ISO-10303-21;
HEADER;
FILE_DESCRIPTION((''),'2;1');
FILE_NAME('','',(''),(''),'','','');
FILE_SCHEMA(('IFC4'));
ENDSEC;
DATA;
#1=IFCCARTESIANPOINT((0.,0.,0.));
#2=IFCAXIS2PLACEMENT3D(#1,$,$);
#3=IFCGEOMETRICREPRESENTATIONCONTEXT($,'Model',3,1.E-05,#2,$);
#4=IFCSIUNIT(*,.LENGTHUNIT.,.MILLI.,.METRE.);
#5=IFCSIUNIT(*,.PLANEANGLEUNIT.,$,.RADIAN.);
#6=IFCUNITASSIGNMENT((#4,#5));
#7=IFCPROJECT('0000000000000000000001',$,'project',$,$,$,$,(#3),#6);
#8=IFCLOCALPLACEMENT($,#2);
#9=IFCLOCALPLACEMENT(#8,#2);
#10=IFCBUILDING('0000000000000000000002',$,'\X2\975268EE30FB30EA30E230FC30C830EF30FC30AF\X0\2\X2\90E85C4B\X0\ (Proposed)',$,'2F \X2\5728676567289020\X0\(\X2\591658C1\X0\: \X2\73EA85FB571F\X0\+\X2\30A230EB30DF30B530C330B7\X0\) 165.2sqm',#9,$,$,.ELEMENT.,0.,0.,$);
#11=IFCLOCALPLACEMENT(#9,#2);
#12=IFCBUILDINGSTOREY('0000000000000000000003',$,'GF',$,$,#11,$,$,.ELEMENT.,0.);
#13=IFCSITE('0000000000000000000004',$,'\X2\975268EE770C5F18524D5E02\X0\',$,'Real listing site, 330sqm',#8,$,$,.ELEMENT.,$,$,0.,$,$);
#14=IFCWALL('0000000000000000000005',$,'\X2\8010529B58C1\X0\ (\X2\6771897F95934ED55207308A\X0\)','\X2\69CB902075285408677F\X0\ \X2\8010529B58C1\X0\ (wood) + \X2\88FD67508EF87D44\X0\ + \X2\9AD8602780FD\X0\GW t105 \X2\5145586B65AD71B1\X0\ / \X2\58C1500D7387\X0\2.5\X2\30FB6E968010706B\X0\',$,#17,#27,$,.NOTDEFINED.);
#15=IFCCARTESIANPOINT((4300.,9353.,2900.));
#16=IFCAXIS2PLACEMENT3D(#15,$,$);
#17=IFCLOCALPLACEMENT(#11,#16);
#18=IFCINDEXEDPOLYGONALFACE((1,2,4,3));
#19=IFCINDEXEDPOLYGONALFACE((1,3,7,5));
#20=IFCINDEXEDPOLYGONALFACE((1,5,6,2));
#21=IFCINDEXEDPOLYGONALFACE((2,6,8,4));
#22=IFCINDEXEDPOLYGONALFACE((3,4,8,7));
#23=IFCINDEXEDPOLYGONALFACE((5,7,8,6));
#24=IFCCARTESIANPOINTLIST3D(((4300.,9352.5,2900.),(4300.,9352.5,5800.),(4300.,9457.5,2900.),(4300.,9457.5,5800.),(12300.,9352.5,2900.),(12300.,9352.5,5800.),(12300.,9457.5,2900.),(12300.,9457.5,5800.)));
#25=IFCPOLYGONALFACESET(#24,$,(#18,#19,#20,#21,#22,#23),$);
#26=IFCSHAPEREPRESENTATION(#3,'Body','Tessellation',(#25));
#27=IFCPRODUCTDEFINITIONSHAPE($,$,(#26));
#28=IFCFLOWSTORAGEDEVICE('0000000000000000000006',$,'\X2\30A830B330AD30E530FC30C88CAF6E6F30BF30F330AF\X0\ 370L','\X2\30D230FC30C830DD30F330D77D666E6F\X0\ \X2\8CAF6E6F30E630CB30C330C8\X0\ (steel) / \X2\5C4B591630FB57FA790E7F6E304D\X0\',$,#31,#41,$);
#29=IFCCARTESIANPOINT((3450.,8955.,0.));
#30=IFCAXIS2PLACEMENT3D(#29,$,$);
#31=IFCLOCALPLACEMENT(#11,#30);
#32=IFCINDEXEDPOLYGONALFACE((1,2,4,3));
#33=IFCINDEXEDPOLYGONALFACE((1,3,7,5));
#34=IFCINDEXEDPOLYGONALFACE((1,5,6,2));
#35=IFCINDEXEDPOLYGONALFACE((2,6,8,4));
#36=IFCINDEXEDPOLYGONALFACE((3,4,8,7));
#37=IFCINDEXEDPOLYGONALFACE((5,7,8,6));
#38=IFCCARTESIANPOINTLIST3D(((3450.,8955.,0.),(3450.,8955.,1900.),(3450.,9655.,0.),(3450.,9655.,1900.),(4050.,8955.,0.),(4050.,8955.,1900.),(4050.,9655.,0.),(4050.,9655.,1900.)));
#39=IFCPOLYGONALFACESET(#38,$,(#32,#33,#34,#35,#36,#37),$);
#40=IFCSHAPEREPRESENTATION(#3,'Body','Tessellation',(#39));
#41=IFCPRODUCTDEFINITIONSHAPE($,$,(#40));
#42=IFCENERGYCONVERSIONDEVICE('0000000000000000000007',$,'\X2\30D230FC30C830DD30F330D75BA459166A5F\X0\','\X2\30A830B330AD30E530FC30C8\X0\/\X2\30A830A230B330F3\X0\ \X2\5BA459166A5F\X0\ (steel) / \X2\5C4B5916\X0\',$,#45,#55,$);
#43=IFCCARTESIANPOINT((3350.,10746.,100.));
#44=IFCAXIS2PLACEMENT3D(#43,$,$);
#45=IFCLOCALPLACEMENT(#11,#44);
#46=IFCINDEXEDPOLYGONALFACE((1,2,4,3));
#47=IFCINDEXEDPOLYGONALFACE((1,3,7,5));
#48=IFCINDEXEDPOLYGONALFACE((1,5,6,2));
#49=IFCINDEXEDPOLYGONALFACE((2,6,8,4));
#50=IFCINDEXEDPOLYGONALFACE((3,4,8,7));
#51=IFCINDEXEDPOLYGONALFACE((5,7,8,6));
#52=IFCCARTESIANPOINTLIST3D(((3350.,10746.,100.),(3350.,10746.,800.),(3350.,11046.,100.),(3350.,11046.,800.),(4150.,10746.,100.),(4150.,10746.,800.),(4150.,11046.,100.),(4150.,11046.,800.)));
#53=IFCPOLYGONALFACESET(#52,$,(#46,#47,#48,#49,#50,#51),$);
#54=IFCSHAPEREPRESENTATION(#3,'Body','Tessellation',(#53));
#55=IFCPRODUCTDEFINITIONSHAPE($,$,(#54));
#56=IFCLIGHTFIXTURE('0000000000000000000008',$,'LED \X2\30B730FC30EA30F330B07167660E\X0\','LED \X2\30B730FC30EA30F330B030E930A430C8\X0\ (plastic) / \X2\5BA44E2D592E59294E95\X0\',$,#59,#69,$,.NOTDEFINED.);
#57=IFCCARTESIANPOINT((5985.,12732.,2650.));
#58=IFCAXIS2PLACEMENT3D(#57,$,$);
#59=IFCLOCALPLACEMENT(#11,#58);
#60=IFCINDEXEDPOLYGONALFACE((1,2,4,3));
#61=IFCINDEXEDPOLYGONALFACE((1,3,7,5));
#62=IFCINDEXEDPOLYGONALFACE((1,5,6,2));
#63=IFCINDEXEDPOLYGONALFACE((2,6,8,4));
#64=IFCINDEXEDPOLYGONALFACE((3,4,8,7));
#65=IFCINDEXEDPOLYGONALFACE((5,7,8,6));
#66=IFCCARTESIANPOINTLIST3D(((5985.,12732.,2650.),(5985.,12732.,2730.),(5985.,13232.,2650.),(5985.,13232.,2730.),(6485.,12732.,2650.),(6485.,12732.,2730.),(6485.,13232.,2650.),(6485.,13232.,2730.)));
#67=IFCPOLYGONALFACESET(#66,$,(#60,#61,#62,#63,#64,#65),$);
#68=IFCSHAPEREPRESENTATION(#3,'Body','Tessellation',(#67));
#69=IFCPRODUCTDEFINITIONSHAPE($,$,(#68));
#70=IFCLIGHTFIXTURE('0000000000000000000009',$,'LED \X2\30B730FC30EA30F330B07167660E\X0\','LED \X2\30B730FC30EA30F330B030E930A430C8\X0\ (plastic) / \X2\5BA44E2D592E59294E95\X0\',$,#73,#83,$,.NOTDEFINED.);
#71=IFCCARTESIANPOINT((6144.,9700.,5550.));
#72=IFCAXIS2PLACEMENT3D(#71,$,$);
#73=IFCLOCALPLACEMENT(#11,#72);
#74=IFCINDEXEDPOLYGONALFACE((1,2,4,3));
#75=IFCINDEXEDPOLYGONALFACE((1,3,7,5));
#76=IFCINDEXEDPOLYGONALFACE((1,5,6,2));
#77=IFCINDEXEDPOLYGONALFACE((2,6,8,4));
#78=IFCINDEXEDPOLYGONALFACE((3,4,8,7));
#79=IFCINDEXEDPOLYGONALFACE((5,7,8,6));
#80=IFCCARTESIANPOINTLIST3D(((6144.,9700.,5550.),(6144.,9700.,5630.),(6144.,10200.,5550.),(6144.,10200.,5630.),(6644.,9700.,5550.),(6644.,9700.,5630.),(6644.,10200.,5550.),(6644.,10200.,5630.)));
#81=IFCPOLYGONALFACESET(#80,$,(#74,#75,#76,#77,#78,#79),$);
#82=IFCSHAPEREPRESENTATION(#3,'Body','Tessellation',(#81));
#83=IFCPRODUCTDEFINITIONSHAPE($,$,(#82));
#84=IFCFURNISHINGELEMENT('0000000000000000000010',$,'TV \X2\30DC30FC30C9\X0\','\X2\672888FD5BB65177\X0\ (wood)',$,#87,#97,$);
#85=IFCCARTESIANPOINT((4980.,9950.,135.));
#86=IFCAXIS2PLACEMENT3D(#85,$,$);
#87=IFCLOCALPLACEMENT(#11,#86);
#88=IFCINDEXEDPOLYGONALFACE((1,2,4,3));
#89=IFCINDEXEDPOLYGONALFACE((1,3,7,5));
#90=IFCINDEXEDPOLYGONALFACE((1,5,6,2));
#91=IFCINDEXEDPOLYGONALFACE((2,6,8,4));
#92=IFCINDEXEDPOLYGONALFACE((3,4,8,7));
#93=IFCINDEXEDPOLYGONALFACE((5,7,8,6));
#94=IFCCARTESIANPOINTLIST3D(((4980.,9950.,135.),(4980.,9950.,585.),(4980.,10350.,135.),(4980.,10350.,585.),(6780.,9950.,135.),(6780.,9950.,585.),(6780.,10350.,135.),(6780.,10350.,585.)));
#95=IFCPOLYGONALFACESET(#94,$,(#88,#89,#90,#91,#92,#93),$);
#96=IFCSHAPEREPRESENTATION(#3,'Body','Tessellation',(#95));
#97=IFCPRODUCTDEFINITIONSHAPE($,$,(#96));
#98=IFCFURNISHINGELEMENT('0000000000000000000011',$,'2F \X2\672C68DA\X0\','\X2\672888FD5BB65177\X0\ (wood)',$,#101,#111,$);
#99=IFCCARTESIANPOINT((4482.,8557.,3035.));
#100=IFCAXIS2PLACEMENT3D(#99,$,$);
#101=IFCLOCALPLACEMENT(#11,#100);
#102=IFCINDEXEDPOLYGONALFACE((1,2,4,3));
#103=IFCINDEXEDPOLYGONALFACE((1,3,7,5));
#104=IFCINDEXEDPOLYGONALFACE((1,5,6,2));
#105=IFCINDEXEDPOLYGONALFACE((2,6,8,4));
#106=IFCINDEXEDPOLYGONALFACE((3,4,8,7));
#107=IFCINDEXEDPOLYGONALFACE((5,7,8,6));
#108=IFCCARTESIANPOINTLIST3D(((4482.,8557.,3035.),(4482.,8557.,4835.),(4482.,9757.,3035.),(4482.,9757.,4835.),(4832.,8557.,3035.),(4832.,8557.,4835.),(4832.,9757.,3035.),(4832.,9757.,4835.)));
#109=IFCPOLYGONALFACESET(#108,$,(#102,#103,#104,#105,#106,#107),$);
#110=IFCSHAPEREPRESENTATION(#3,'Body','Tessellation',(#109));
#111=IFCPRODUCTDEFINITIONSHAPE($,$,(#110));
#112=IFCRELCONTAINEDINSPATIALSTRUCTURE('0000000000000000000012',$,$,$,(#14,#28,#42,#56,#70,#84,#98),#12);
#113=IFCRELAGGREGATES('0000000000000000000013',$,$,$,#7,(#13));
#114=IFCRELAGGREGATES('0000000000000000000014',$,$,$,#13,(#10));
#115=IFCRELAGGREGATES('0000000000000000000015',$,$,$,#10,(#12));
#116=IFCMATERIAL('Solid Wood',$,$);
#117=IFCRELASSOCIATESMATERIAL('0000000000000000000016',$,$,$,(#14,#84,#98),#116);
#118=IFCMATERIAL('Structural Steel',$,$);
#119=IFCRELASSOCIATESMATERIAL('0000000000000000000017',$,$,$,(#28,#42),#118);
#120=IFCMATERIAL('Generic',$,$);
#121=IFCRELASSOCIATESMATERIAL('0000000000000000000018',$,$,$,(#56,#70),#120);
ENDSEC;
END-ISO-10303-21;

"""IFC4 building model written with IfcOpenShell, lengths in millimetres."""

from ifc_helpers import new_model, si_unit, frame, frame_2d, origin, place, context, project, spatial, rectangle, extrude, material, element, save


model = new_model("IFC4")

# Units and contexts
model_context = context("Model", 3, precision=1e-05, world=origin())
ifc_project = project(units=[si_unit("LENGTHUNIT", "METRE", prefix="MILLI"), si_unit("PLANEANGLEUNIT", "RADIAN")], contexts=[model_context])

# Site, building, storey
site_placement = place(None, origin())
site = spatial("IfcSite", under=ifc_project, at=site_placement, Name="青森県弘前市", ObjectType="Real listing site, 330sqm", CompositionType="ELEMENT", RefElevation=0.0)
building_placement = place(site_placement, origin())
building = spatial("IfcBuilding", under=site, at=building_placement, Name="青森・リモートワーク2部屋 (Proposed)", ObjectType="2F 在来木造(外壁: 珪藻土+アルミサッシ) 165.2sqm", CompositionType="ELEMENT", ElevationOfRefHeight=0.0, ElevationOfTerrain=0.0)
storey_placement = place(building_placement, origin())
storey = spatial("IfcBuildingStorey", under=building, at=storey_placement, Name="GF", CompositionType="ELEMENT", Elevation=0.0)

# Shared definitions
ifc_material_1 = material(Name="Solid Wood")

# Wall
wall_1_placement = place(storey_placement, frame((4300.0, 9353.0, 2900.0)))
element("IfcWall", 1, at=wall_1_placement, inside=storey, material=ifc_material_1, Name="耐力壁 (東西間仕切り)", Description="構造用合板 耐力壁 (wood) + 製材軸組 + 高性能GW t105 充填断熱 / 壁倍率2.5・準耐火", PredefinedType="NOTDEFINED", context=model_context, shape_type="SweptSolid", body=[
    extrude(rectangle(XDim=8000.0, YDim=105.0, at=frame_2d((4000.0, 52.0))), frame((4300.0, 9353.0, 2900.0)), (0.0, 0.0, 1.0), 2900.0),
])

# Flow storage device
ifc_material_2 = material(Name="Structural Steel")
flow_storage_device_placement = place(storey_placement, frame((3450.0, 8955.0, 0.0)))
element("IfcFlowStorageDevice", 2, at=flow_storage_device_placement, inside=storey, material=ifc_material_2, Name="エコキュート貯湯タンク 370L", Description="ヒートポンプ給湯 貯湯ユニット (steel) / 屋外・基礎置き", context=model_context, shape_type="SweptSolid", body=[
    extrude(rectangle(XDim=600.0, YDim=700.0, at=frame_2d((300.0, 350.0))), frame((3450.0, 8955.0, 0.0)), (0.0, 0.0, 1.0), 1900.0),
])

# Energy conversion device
energy_conversion_device_placement = place(storey_placement, frame((3350.0, 10746.0, 100.0)))
element("IfcEnergyConversionDevice", 3, at=energy_conversion_device_placement, inside=storey, material=ifc_material_2, Name="ヒートポンプ室外機", Description="エコキュート/エアコン 室外機 (steel) / 屋外", context=model_context, shape_type="SweptSolid", body=[
    extrude(rectangle(XDim=800.0, YDim=300.0, at=frame_2d((400.0, 150.0))), frame((3350.0, 10746.0, 100.0)), (0.0, 0.0, 1.0), 700.0),
])

# Light fixtures
ifc_material_3 = material(Name="Generic")
light_fixture_1_placement = place(storey_placement, frame((5985.0, 12732.0, 2650.0)))
element("IfcLightFixture", 4, at=light_fixture_1_placement, inside=storey, material=ifc_material_3, Name="LED シーリング照明", Description="LED シーリングライト (plastic) / 室中央天井", PredefinedType="NOTDEFINED", context=model_context, shape_type="SweptSolid", body=[
    extrude(rectangle(XDim=500.0, YDim=500.0, at=frame_2d((250.0, 250.0))), frame((5985.0, 12732.0, 2650.0)), (0.0, 0.0, 1.0), 80.0),
])
light_fixture_2_placement = place(storey_placement, frame((6144.0, 9700.0, 5550.0)))
element("IfcLightFixture", 5, at=light_fixture_2_placement, inside=storey, material=ifc_material_3, Name="LED シーリング照明", Description="LED シーリングライト (plastic) / 室中央天井", PredefinedType="NOTDEFINED", context=model_context, shape_type="SweptSolid", body=[
    extrude(rectangle(XDim=500.0, YDim=500.0, at=frame_2d((250.0, 250.0))), frame((6144.0, 9700.0, 5550.0)), (0.0, 0.0, 1.0), 80.0),
])

# Furnishing elements
furnishing_1_placement = place(storey_placement, frame((4980.0, 9950.0, 135.0)))
element("IfcFurnishingElement", 6, at=furnishing_1_placement, inside=storey, material=ifc_material_1, Name="TV ボード", Description="木製家具 (wood)", context=model_context, shape_type="SweptSolid", body=[
    extrude(rectangle(XDim=1800.0, YDim=400.0, at=frame_2d((900.0, 200.0))), frame((4980.0, 9950.0, 135.0)), (0.0, 0.0, 1.0), 450.0),
])
furnishing_2_placement = place(storey_placement, frame((4482.0, 8557.0, 3035.0)))
element("IfcFurnishingElement", 7, at=furnishing_2_placement, inside=storey, material=ifc_material_1, Name="2F 本棚", Description="木製家具 (wood)", context=model_context, shape_type="SweptSolid", body=[
    extrude(rectangle(XDim=350.0, YDim=1200.0, at=frame_2d((175.0, 600.0))), frame((4482.0, 8557.0, 3035.0)), (0.0, 0.0, 1.0), 1800.0),
])

save(model, "model.ifc")
